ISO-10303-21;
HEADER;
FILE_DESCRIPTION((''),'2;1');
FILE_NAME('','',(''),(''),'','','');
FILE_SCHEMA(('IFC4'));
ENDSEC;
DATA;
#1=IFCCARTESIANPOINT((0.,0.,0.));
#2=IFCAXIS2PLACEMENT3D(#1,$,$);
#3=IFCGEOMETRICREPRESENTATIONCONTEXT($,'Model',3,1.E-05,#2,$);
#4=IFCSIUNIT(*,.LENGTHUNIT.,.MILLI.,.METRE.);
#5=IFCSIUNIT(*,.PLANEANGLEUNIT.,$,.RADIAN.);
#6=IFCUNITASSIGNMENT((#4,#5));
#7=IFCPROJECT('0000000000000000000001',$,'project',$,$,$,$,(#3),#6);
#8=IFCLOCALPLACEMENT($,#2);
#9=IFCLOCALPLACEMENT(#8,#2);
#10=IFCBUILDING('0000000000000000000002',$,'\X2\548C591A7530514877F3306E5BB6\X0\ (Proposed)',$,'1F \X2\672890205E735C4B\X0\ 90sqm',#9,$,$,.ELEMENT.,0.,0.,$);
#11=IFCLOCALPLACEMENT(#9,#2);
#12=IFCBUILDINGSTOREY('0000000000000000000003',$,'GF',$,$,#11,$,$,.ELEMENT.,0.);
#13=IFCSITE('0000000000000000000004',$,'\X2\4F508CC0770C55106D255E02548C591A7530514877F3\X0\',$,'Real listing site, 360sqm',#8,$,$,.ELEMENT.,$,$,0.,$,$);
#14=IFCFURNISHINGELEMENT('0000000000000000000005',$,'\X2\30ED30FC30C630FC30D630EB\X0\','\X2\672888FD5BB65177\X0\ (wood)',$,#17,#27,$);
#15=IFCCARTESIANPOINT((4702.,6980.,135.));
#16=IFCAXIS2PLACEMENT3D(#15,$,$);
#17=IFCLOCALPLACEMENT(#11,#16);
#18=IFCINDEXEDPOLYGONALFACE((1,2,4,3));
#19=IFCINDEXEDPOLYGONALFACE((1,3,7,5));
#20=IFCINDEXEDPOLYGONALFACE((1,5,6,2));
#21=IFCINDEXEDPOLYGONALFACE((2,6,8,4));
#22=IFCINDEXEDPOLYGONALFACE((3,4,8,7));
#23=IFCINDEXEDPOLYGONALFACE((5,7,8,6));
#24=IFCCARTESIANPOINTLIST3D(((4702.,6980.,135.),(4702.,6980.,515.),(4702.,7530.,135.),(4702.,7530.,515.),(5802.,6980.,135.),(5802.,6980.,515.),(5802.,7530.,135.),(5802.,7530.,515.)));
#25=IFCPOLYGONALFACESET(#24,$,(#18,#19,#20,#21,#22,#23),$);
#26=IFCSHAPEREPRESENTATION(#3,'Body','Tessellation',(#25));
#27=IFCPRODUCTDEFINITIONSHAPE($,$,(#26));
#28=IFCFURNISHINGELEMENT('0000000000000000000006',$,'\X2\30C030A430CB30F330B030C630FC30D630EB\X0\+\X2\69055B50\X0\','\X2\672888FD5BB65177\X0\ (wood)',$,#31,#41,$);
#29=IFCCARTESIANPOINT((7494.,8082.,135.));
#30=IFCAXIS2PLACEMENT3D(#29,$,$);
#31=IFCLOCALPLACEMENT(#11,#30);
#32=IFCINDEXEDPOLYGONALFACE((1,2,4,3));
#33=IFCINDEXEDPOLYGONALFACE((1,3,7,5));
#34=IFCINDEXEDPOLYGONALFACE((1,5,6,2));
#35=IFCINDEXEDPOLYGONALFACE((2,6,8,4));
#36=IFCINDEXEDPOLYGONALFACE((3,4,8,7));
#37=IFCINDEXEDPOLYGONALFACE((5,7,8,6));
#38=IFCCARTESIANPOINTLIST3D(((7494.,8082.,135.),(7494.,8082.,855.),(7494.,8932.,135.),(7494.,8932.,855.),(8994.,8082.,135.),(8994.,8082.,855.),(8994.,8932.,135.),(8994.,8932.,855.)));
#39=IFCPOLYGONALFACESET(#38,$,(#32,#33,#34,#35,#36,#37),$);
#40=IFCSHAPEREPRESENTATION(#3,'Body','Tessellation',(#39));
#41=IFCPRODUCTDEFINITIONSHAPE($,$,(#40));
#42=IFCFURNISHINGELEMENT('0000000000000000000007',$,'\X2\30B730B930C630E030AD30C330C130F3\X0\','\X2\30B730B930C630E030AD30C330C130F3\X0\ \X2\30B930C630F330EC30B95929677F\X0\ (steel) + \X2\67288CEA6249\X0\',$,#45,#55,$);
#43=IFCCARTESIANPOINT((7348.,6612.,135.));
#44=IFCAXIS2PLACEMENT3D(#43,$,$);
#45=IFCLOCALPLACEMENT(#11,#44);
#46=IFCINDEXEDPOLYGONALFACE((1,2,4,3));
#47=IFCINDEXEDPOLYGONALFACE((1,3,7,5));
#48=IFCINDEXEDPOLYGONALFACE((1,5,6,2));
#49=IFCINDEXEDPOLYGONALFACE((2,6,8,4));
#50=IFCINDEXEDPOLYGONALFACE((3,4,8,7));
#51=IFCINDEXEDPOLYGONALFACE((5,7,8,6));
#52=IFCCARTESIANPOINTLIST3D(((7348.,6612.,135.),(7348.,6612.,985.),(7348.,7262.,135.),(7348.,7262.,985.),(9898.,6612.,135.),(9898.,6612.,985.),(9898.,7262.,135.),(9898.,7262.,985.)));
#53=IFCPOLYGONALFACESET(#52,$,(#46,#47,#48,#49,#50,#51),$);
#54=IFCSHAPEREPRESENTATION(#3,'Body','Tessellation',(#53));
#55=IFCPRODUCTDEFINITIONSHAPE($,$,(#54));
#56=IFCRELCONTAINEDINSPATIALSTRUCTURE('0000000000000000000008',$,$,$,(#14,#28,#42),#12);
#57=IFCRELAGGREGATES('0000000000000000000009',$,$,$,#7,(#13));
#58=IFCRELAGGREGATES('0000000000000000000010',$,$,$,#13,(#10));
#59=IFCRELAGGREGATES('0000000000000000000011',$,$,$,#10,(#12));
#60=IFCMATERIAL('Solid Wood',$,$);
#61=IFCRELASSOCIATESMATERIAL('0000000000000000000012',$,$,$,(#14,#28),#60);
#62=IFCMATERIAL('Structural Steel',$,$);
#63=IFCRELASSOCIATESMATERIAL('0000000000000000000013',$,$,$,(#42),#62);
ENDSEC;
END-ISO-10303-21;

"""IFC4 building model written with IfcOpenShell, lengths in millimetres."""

from ifc_helpers import new_model, si_unit, frame, frame_2d, origin, place, context, project, spatial, rectangle, extrude, material, element, save


model = new_model("IFC4")

# Units and contexts
model_context = context("Model", 3, precision=1e-05, world=origin())
ifc_project = project(units=[si_unit("LENGTHUNIT", "METRE", prefix="MILLI"), si_unit("PLANEANGLEUNIT", "RADIAN")], contexts=[model_context])

# Site, building, storey
site_placement = place(None, origin())
site = spatial("IfcSite", under=ifc_project, at=site_placement, Name="佐賀県唐津市和多田先石", ObjectType="Real listing site, 360sqm", CompositionType="ELEMENT", RefElevation=0.0)
building_placement = place(site_placement, origin())
building = spatial("IfcBuilding", under=site, at=building_placement, Name="和多田先石の家 (Proposed)", ObjectType="1F 木造平屋 90sqm", CompositionType="ELEMENT", ElevationOfRefHeight=0.0, ElevationOfTerrain=0.0)
storey_placement = place(building_placement, origin())
storey = spatial("IfcBuildingStorey", under=building, at=storey_placement, Name="GF", CompositionType="ELEMENT", Elevation=0.0)

# Shared definitions
ifc_material_1 = material(Name="Solid Wood")

# Shared definitions
ifc_material_2 = material(Name="Structural Steel")

# Furnishing elements
furnishing_1_placement = place(storey_placement, frame((4702.0, 6980.0, 135.0)))
element("IfcFurnishingElement", 1, at=furnishing_1_placement, inside=storey, material=ifc_material_1, Name="ローテーブル", Description="木製家具 (wood)", context=model_context, shape_type="SweptSolid", body=[
    extrude(rectangle(XDim=1100.0, YDim=550.0, at=frame_2d((550.0, 275.0))), frame((4702.0, 6980.0, 135.0)), (0.0, 0.0, 1.0), 380.0),
])
furnishing_2_placement = place(storey_placement, frame((7494.0, 8082.0, 135.0)))
element("IfcFurnishingElement", 2, at=furnishing_2_placement, inside=storey, material=ifc_material_1, Name="ダイニングテーブル+椅子", Description="木製家具 (wood)", context=model_context, shape_type="SweptSolid", body=[
    extrude(rectangle(XDim=1500.0, YDim=850.0, at=frame_2d((750.0, 425.0))), frame((7494.0, 8082.0, 135.0)), (0.0, 0.0, 1.0), 720.0),
])
furnishing_3_placement = place(storey_placement, frame((7348.0, 6612.0, 135.0)))
element("IfcFurnishingElement", 3, at=furnishing_3_placement, inside=storey, material=ifc_material_2, Name="システムキッチン", Description="システムキッチン ステンレス天板 (steel) + 木質扉", context=model_context, shape_type="SweptSolid", body=[
    extrude(rectangle(XDim=2550.0, YDim=650.0, at=frame_2d((1275.0, 325.0))), frame((7348.0, 6612.0, 135.0)), (0.0, 0.0, 1.0), 850.0),
])

save(model, "model.ifc")
